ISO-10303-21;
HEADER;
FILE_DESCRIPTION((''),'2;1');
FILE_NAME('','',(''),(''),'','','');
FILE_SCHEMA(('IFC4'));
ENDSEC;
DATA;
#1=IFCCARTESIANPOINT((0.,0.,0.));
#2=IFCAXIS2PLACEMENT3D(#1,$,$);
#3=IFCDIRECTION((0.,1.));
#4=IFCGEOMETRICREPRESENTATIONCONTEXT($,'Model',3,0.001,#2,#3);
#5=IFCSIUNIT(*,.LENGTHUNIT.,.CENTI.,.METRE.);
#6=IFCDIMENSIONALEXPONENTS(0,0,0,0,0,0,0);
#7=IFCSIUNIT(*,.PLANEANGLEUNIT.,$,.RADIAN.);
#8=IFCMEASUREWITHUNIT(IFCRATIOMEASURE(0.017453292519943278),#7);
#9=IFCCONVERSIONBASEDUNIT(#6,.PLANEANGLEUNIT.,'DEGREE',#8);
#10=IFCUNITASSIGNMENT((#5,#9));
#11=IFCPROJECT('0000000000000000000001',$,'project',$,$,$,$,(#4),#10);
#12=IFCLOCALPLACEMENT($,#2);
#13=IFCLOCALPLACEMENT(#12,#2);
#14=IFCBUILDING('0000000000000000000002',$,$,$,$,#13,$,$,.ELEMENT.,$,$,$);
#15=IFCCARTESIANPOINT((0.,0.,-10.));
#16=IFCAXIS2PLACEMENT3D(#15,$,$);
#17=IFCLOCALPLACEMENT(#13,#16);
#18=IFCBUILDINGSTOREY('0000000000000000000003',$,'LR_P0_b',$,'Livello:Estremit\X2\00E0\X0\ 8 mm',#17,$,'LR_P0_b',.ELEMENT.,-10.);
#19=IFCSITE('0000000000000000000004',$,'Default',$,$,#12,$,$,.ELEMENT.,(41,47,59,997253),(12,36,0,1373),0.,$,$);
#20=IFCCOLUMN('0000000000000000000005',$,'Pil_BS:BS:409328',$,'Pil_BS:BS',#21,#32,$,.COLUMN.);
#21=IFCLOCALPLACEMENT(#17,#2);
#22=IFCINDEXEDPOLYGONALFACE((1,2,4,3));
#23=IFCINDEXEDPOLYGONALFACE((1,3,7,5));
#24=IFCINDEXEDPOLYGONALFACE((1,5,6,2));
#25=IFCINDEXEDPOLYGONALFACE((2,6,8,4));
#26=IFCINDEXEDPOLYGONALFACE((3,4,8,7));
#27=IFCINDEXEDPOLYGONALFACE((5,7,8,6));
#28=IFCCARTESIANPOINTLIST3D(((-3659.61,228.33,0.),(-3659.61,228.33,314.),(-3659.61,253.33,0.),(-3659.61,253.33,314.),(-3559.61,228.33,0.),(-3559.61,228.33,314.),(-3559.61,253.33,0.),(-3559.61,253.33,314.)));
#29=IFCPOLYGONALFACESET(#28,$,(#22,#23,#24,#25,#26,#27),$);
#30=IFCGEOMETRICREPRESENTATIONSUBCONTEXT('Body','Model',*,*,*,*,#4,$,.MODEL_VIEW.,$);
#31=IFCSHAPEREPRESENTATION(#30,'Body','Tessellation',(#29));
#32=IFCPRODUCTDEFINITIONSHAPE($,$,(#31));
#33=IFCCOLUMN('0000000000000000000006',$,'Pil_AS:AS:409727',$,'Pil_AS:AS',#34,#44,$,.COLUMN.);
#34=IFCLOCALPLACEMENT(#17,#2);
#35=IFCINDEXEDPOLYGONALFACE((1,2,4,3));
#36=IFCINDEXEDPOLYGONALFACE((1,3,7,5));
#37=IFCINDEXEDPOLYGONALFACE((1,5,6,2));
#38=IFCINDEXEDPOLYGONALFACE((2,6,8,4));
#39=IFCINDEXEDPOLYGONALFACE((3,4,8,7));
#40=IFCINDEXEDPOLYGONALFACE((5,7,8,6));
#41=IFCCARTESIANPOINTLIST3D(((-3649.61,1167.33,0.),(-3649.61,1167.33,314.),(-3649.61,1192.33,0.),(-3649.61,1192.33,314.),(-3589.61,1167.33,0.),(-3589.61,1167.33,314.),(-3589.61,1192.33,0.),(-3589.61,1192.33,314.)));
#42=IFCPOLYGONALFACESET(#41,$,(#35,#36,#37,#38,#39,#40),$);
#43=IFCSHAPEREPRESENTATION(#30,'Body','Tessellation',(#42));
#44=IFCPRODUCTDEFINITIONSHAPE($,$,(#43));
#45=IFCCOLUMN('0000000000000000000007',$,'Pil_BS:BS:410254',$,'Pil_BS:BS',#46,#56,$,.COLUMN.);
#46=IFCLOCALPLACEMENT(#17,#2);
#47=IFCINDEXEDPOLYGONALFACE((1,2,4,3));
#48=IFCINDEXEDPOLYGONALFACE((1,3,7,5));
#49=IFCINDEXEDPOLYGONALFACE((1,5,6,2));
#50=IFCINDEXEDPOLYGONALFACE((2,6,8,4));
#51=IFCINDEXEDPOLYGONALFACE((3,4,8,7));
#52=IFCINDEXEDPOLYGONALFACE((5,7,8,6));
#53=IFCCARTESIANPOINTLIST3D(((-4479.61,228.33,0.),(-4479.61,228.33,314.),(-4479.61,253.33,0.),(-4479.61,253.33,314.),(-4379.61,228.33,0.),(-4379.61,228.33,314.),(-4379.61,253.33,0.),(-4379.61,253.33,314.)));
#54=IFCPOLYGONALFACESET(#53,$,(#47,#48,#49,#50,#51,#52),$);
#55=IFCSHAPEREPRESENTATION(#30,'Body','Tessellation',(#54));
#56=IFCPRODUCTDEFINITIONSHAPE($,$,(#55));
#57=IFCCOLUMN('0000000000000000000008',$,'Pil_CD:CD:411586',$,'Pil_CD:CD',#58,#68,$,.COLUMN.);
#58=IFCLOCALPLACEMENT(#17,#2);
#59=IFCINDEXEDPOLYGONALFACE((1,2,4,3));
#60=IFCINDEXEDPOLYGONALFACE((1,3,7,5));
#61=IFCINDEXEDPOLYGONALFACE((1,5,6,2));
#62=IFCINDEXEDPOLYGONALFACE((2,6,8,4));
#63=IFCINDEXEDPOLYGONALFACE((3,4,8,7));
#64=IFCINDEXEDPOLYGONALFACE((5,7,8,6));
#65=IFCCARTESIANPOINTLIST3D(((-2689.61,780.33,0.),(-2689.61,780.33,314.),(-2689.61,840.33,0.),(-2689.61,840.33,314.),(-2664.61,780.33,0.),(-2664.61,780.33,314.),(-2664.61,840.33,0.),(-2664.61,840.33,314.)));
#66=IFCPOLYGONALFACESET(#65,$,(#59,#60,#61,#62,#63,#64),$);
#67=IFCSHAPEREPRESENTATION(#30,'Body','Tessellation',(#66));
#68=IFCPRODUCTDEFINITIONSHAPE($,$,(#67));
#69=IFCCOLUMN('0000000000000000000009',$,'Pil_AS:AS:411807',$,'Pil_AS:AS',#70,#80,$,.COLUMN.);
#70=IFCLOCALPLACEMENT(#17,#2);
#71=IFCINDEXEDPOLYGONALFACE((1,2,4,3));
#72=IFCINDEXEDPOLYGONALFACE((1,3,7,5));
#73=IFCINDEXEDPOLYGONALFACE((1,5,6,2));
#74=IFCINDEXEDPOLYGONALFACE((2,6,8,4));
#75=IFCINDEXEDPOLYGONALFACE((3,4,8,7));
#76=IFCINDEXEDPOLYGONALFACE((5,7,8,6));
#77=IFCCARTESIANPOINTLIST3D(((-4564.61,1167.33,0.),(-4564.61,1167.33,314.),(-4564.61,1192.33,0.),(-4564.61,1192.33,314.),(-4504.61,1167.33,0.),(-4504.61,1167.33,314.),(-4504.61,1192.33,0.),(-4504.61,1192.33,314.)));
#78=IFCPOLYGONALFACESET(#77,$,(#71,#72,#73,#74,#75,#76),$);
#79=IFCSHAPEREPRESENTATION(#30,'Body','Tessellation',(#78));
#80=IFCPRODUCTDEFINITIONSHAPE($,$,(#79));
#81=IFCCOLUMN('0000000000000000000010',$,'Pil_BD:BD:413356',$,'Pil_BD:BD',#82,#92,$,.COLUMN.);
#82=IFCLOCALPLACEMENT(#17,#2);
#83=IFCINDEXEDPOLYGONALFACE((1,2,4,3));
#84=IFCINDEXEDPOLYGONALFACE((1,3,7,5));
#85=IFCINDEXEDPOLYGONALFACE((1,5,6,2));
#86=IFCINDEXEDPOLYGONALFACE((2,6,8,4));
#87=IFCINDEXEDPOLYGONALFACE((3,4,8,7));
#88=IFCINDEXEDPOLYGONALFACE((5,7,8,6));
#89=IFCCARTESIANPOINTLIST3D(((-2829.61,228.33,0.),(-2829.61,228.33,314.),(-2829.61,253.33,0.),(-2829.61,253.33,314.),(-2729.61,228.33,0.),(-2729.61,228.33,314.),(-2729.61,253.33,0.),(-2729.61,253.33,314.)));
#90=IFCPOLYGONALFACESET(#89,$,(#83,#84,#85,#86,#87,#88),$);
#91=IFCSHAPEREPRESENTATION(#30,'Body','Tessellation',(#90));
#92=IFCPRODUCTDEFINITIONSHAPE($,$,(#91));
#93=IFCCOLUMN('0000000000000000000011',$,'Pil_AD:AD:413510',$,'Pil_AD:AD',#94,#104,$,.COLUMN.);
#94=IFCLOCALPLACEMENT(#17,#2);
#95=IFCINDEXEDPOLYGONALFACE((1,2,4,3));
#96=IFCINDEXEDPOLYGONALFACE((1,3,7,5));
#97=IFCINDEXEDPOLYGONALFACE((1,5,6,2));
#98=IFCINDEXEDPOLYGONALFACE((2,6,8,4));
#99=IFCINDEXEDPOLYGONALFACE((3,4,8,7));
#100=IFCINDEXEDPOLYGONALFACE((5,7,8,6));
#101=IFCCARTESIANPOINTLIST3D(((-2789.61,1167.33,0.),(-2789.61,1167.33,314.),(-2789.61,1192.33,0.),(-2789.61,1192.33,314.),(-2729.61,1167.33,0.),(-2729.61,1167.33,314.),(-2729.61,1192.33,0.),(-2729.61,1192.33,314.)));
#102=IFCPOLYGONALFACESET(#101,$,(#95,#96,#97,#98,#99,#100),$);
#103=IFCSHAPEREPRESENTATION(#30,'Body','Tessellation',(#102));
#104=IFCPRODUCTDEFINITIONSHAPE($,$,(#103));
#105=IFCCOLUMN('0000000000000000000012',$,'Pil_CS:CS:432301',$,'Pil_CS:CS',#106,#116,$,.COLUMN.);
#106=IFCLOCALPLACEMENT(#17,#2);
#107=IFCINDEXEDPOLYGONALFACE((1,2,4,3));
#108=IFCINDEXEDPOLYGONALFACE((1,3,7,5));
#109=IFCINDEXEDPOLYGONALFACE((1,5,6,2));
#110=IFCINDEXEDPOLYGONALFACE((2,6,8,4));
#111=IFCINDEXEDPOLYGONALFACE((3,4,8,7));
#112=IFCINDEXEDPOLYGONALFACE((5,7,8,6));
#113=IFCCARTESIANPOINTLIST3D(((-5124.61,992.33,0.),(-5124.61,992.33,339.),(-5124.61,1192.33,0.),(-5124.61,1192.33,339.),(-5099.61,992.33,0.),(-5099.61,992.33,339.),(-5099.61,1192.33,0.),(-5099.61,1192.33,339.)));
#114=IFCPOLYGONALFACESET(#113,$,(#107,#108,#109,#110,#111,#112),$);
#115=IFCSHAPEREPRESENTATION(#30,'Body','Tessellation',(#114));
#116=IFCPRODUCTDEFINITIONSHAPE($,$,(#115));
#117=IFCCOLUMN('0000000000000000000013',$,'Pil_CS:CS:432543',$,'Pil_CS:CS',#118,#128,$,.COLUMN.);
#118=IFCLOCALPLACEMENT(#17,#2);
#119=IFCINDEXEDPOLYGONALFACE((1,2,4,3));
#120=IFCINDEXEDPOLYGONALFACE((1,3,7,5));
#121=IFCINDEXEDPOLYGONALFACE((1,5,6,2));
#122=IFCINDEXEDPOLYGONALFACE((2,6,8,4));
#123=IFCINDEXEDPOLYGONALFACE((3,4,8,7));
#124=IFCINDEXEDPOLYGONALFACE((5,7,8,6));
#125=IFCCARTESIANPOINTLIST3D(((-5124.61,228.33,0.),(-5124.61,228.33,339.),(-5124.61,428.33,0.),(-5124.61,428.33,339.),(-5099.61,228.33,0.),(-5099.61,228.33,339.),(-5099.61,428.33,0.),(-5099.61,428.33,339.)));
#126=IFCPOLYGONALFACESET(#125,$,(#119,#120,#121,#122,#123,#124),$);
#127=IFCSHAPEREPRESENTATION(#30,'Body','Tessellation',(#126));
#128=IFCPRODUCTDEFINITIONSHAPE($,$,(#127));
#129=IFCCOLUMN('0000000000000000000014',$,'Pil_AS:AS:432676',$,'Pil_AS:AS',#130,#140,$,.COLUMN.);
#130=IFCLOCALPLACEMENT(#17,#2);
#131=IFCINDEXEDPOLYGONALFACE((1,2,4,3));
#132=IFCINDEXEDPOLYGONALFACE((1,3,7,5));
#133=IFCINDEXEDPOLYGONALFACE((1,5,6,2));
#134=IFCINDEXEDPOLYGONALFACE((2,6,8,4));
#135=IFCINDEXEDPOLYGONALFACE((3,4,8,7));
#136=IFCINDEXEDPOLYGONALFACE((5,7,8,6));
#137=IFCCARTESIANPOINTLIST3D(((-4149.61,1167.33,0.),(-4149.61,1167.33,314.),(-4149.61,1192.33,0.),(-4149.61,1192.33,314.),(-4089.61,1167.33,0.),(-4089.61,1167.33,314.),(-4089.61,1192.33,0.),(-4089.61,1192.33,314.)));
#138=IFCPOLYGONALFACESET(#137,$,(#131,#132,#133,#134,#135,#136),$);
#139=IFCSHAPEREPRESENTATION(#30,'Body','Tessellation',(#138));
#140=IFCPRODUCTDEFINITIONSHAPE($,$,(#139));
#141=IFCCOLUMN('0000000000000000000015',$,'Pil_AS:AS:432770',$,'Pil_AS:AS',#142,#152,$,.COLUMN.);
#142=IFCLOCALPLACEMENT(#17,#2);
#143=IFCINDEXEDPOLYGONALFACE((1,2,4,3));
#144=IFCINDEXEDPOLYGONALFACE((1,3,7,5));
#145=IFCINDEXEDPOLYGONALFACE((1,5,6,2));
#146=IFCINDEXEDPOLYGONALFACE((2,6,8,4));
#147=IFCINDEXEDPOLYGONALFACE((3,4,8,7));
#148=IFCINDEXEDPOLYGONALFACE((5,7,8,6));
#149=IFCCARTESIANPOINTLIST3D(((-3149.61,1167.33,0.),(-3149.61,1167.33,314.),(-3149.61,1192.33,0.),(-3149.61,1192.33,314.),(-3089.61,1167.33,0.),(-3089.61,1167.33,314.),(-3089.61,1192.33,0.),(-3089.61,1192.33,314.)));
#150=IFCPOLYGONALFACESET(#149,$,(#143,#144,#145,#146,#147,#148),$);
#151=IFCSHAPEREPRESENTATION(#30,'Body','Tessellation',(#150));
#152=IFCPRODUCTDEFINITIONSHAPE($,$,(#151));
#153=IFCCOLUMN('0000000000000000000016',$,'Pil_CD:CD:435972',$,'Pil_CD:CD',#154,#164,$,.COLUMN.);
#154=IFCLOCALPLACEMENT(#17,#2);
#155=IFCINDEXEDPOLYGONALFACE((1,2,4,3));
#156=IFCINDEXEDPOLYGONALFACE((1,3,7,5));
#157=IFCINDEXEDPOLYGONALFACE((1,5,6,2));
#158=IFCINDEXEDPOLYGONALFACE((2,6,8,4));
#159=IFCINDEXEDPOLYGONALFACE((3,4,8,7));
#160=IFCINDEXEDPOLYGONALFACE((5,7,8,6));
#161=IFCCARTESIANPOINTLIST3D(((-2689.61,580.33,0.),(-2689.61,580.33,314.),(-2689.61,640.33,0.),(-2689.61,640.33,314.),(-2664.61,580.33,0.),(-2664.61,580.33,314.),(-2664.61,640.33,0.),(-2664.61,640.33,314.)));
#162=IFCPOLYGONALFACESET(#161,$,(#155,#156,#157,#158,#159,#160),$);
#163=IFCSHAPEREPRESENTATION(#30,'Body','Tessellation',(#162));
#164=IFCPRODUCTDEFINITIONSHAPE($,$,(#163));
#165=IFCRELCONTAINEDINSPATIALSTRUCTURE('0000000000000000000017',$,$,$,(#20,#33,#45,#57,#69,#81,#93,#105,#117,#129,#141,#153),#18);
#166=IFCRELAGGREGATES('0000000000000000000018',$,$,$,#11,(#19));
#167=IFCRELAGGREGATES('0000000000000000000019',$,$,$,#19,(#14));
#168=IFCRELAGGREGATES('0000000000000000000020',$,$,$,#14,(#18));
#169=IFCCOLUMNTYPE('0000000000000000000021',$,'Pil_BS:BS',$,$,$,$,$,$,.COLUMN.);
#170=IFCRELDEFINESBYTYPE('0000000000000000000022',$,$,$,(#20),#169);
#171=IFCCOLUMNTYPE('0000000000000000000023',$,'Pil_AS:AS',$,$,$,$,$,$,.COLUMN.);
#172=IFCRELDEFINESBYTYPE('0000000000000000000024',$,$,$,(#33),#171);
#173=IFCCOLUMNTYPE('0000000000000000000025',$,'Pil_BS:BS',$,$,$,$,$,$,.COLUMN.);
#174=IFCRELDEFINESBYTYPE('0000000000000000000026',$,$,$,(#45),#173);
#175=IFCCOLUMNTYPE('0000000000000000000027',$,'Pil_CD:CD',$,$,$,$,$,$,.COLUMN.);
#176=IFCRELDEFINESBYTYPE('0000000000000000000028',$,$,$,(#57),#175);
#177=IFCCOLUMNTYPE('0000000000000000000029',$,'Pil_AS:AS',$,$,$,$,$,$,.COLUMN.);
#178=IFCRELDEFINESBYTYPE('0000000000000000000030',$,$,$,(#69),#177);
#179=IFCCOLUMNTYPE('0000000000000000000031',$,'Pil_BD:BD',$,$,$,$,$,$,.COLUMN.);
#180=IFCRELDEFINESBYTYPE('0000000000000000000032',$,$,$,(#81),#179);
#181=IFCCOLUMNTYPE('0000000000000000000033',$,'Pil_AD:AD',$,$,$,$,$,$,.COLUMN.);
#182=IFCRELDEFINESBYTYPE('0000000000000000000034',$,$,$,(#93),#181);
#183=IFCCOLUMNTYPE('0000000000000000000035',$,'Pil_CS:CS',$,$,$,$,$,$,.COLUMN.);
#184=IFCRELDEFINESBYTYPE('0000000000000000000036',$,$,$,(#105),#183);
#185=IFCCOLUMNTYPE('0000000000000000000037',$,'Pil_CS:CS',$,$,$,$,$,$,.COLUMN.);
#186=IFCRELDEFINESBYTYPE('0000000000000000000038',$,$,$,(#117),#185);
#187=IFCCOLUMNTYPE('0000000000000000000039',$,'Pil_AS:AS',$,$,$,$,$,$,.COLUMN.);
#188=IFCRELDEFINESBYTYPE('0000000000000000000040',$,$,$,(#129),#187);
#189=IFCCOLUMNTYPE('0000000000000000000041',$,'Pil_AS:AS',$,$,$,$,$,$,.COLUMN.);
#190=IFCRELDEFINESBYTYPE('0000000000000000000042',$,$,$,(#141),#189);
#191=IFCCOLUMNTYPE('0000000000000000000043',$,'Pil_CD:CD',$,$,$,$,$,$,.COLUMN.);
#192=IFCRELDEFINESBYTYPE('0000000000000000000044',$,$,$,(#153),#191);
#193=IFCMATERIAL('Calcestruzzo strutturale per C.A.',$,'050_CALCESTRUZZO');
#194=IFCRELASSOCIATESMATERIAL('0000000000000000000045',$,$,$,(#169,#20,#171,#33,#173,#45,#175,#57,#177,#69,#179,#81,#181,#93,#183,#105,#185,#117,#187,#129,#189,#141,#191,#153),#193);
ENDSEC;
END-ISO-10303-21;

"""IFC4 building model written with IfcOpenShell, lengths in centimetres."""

from ifc_helpers import new_model, entity, si_unit, converted_unit, direction, frame, origin, place, context, subcontext, project, spatial, indexed_curve, outline, extrude, source, transform, mapped, material, type_object, type_shapes, element, save


model = new_model("IFC4")

# Units and contexts
model_context = context("Model", 3, precision=0.001, world=origin(), true_north=direction((0.0, 1.0)))
body_context = subcontext(model_context, "Body", "Model", "MODEL_VIEW")
ifc_project = project(units=[si_unit("LENGTHUNIT", "METRE", prefix="CENTI"), converted_unit("PLANEANGLEUNIT", "DEGREE", entity("IfcRatioMeasure", 0.017453292519943278), si_unit("PLANEANGLEUNIT", "RADIAN"), dimensions=[0, 0, 0, 0, 0, 0, 0])], contexts=[model_context])

# Site, building, storey
site_placement = place(None, origin())
site = spatial("IfcSite", under=ifc_project, at=site_placement, Name="Default", CompositionType="ELEMENT", RefLatitude=(41, 47, 59, 997253), RefLongitude=(12, 36, 0, 1373), RefElevation=0.0)
building_placement = place(site_placement, origin())
building = spatial("IfcBuilding", under=site, at=building_placement, CompositionType="ELEMENT")
storey_placement = place(building_placement, frame((0.0, 0.0, -10.0)))
storey = spatial("IfcBuildingStorey", under=building, at=storey_placement, Name="LR_P0_b", ObjectType="Livello:Estremità 8 mm", LongName="LR_P0_b", CompositionType="ELEMENT", Elevation=-10.0)

# Columns
ifc_material = material(Name="Calcestruzzo strutturale per C.A.", Category="050_CALCESTRUZZO")
column_type_1 = type_object("IfcColumnType", Name="Pil_BS:BS", PredefinedType="COLUMN", material=ifc_material)
shared_shape_1 = source(origin(), body_context, "Body", "SweptSolid", [
    extrude(outline(indexed_curve([(-12.5, -50.0), (12.5, -50.0), (12.5, 50.0), (-12.5, 50.0), (-12.5, -50.0)], self_intersect=False)), frame((-3609.61, 240.83, -10.0), z_axis=(0.0, 0.0, 1.0), x_axis=(0.0, -1.0, 0.0)), (0.0, 0.0, 1.0), 314.0),
])
type_shapes(column_type_1, [shared_shape_1])
column_1_placement = place(storey_placement, frame((0.0, 0.0, 10.0)))
element("IfcColumn", 1, at=column_1_placement, inside=storey, type_object=column_type_1, material=ifc_material, Name="Pil_BS:BS:409328", ObjectType="Pil_BS:BS", PredefinedType="COLUMN", context=body_context, shape_type="MappedRepresentation", body=[
    mapped(shared_shape_1, transform((0.0, 0.0, 0.0), scale=1.0)),
])
column_type_2 = type_object("IfcColumnType", Name="Pil_AS:AS", PredefinedType="COLUMN", material=ifc_material)
shared_shape_2 = source(origin(), body_context, "Body", "SweptSolid", [
    extrude(outline(indexed_curve([(-12.5, -30.0), (12.5, -30.0), (12.5, 30.0), (-12.5, 30.0), (-12.5, -30.0)], self_intersect=False)), frame((-3619.61, 1179.83, -10.0), z_axis=(0.0, 0.0, 1.0), x_axis=(0.0, -1.0, 0.0)), (0.0, 0.0, 1.0), 314.0),
])
type_shapes(column_type_2, [shared_shape_2])
column_2_placement = place(storey_placement, frame((0.0, 0.0, 10.0)))
element("IfcColumn", 2, at=column_2_placement, inside=storey, type_object=column_type_2, material=ifc_material, Name="Pil_AS:AS:409727", ObjectType="Pil_AS:AS", PredefinedType="COLUMN", context=body_context, shape_type="MappedRepresentation", body=[
    mapped(shared_shape_2, transform((0.0, 0.0, 0.0), scale=1.0)),
])
column_type_3 = type_object("IfcColumnType", Name="Pil_BS:BS", PredefinedType="COLUMN", material=ifc_material)
shared_shape_3 = source(origin(), body_context, "Body", "SweptSolid", [
    extrude(outline(indexed_curve([(-12.5, -50.0), (12.5, -50.0), (12.5, 50.0), (-12.5, 50.0), (-12.5, -50.0)], self_intersect=False)), frame((-4429.61, 240.83, -10.0), z_axis=(0.0, 0.0, 1.0), x_axis=(0.0, -1.0, 0.0)), (0.0, 0.0, 1.0), 314.0),
])
type_shapes(column_type_3, [shared_shape_3])
column_3_placement = place(storey_placement, frame((0.0, 0.0, 10.0)))
element("IfcColumn", 3, at=column_3_placement, inside=storey, type_object=column_type_3, material=ifc_material, Name="Pil_BS:BS:410254", ObjectType="Pil_BS:BS", PredefinedType="COLUMN", context=body_context, shape_type="MappedRepresentation", body=[
    mapped(shared_shape_3, transform((0.0, 0.0, 0.0), scale=1.0)),
])
column_type_4 = type_object("IfcColumnType", Name="Pil_CD:CD", PredefinedType="COLUMN", material=ifc_material)
shared_shape_4 = source(origin(), body_context, "Body", "SweptSolid", [
    extrude(outline(indexed_curve([(-30.0, -12.5), (30.0, -12.5), (30.0, 12.5), (-30.0, 12.5), (-30.0, -12.5)], self_intersect=False)), frame((-2677.11, 810.33, -10.0), z_axis=(0.0, 0.0, 1.0), x_axis=(0.0, -1.0, 0.0)), (0.0, 0.0, 1.0), 314.0),
])
type_shapes(column_type_4, [shared_shape_4])
column_4_placement = place(storey_placement, frame((0.0, 0.0, 10.0)))
element("IfcColumn", 4, at=column_4_placement, inside=storey, type_object=column_type_4, material=ifc_material, Name="Pil_CD:CD:411586", ObjectType="Pil_CD:CD", PredefinedType="COLUMN", context=body_context, shape_type="MappedRepresentation", body=[
    mapped(shared_shape_4, transform((0.0, 0.0, 0.0), scale=1.0)),
])
column_type_5 = type_object("IfcColumnType", Name="Pil_AS:AS", PredefinedType="COLUMN", material=ifc_material)
shared_shape_5 = source(origin(), body_context, "Body", "SweptSolid", [
    extrude(outline(indexed_curve([(-12.5, -30.0), (12.5, -30.0), (12.5, 30.0), (-12.5, 30.0), (-12.5, -30.0)], self_intersect=False)), frame((-4534.61, 1179.83, -10.0), z_axis=(0.0, 0.0, 1.0), x_axis=(0.0, -1.0, 0.0)), (0.0, 0.0, 1.0), 314.0),
])
type_shapes(column_type_5, [shared_shape_5])
column_5_placement = place(storey_placement, frame((0.0, 0.0, 10.0)))
element("IfcColumn", 5, at=column_5_placement, inside=storey, type_object=column_type_5, material=ifc_material, Name="Pil_AS:AS:411807", ObjectType="Pil_AS:AS", PredefinedType="COLUMN", context=body_context, shape_type="MappedRepresentation", body=[
    mapped(shared_shape_5, transform((0.0, 0.0, 0.0), scale=1.0)),
])
column_type_6 = type_object("IfcColumnType", Name="Pil_BD:BD", PredefinedType="COLUMN", material=ifc_material)
shared_shape_6 = source(origin(), body_context, "Body", "SweptSolid", [
    extrude(outline(indexed_curve([(-12.5, -50.0), (12.5, -50.0), (12.5, 50.0), (-12.5, 50.0), (-12.5, -50.0)], self_intersect=False)), frame((-2779.61, 240.83, -10.0), z_axis=(0.0, 0.0, 1.0), x_axis=(0.0, -1.0, 0.0)), (0.0, 0.0, 1.0), 314.0),
])
type_shapes(column_type_6, [shared_shape_6])
column_6_placement = place(storey_placement, frame((0.0, 0.0, 10.0)))
element("IfcColumn", 6, at=column_6_placement, inside=storey, type_object=column_type_6, material=ifc_material, Name="Pil_BD:BD:413356", ObjectType="Pil_BD:BD", PredefinedType="COLUMN", context=body_context, shape_type="MappedRepresentation", body=[
    mapped(shared_shape_6, transform((0.0, 0.0, 0.0), scale=1.0)),
])
column_type_7 = type_object("IfcColumnType", Name="Pil_AD:AD", PredefinedType="COLUMN", material=ifc_material)
shared_shape_7 = source(origin(), body_context, "Body", "SweptSolid", [
    extrude(outline(indexed_curve([(-12.5, -30.0), (12.5, -30.0), (12.5, 30.0), (-12.5, 30.0), (-12.5, -30.0)], self_intersect=False)), frame((-2759.61, 1179.83, -10.0), z_axis=(0.0, 0.0, 1.0), x_axis=(0.0, -1.0, 0.0)), (0.0, 0.0, 1.0), 314.0),
])
type_shapes(column_type_7, [shared_shape_7])
column_7_placement = place(storey_placement, frame((0.0, 0.0, 10.0)))
element("IfcColumn", 7, at=column_7_placement, inside=storey, type_object=column_type_7, material=ifc_material, Name="Pil_AD:AD:413510", ObjectType="Pil_AD:AD", PredefinedType="COLUMN", context=body_context, shape_type="MappedRepresentation", body=[
    mapped(shared_shape_7, transform((0.0, 0.0, 0.0), scale=1.0)),
])
column_type_8 = type_object("IfcColumnType", Name="Pil_CS:CS", PredefinedType="COLUMN", material=ifc_material)
shared_shape_8 = source(origin(), body_context, "Body", "SweptSolid", [
    extrude(outline(indexed_curve([(-100.0, -12.5), (100.0, -12.5), (100.0, 12.5), (-100.0, 12.5), (-100.0, -12.5)], self_intersect=False)), frame((-5112.11, 1092.33, -10.0), z_axis=(0.0, 0.0, 1.0), x_axis=(0.0, -1.0, 0.0)), (0.0, 0.0, 1.0), 339.0),
])
type_shapes(column_type_8, [shared_shape_8])
column_8_placement = place(storey_placement, frame((0.0, 0.0, 10.0)))
element("IfcColumn", 8, at=column_8_placement, inside=storey, type_object=column_type_8, material=ifc_material, Name="Pil_CS:CS:432301", ObjectType="Pil_CS:CS", PredefinedType="COLUMN", context=body_context, shape_type="MappedRepresentation", body=[
    mapped(shared_shape_8, transform((0.0, 0.0, 0.0), scale=1.0)),
])
column_type_9 = type_object("IfcColumnType", Name="Pil_CS:CS", PredefinedType="COLUMN", material=ifc_material)
shared_shape_9 = source(origin(), body_context, "Body", "SweptSolid", [
    extrude(outline(indexed_curve([(-100.0, -12.5), (100.0, -12.5), (100.0, 12.5), (-100.0, 12.5), (-100.0, -12.5)], self_intersect=False)), frame((-5112.11, 328.33, -10.0), z_axis=(0.0, 0.0, 1.0), x_axis=(0.0, -1.0, 0.0)), (0.0, 0.0, 1.0), 339.0),
])
type_shapes(column_type_9, [shared_shape_9])
column_9_placement = place(storey_placement, frame((0.0, 0.0, 10.0)))
element("IfcColumn", 9, at=column_9_placement, inside=storey, type_object=column_type_9, material=ifc_material, Name="Pil_CS:CS:432543", ObjectType="Pil_CS:CS", PredefinedType="COLUMN", context=body_context, shape_type="MappedRepresentation", body=[
    mapped(shared_shape_9, transform((0.0, 0.0, 0.0), scale=1.0)),
])
column_type_10 = type_object("IfcColumnType", Name="Pil_AS:AS", PredefinedType="COLUMN", material=ifc_material)
shared_shape_10 = source(origin(), body_context, "Body", "SweptSolid", [
    extrude(outline(indexed_curve([(-12.5, -30.0), (12.5, -30.0), (12.5, 30.0), (-12.5, 30.0), (-12.5, -30.0)], self_intersect=False)), frame((-4119.61, 1179.83, -10.0), z_axis=(0.0, 0.0, 1.0), x_axis=(0.0, -1.0, 0.0)), (0.0, 0.0, 1.0), 314.0),
])
type_shapes(column_type_10, [shared_shape_10])
column_10_placement = place(storey_placement, frame((0.0, 0.0, 10.0)))
element("IfcColumn", 10, at=column_10_placement, inside=storey, type_object=column_type_10, material=ifc_material, Name="Pil_AS:AS:432676", ObjectType="Pil_AS:AS", PredefinedType="COLUMN", context=body_context, shape_type="MappedRepresentation", body=[
    mapped(shared_shape_10, transform((0.0, 0.0, 0.0), scale=1.0)),
])
column_type_11 = type_object("IfcColumnType", Name="Pil_AS:AS", PredefinedType="COLUMN", material=ifc_material)
shared_shape_11 = source(origin(), body_context, "Body", "SweptSolid", [
    extrude(outline(indexed_curve([(-12.5, -30.0), (12.5, -30.0), (12.5, 30.0), (-12.5, 30.0), (-12.5, -30.0)], self_intersect=False)), frame((-3119.61, 1179.83, -10.0), z_axis=(0.0, 0.0, 1.0), x_axis=(0.0, -1.0, 0.0)), (0.0, 0.0, 1.0), 314.0),
])
type_shapes(column_type_11, [shared_shape_11])
column_11_placement = place(storey_placement, frame((0.0, 0.0, 10.0)))
element("IfcColumn", 11, at=column_11_placement, inside=storey, type_object=column_type_11, material=ifc_material, Name="Pil_AS:AS:432770", ObjectType="Pil_AS:AS", PredefinedType="COLUMN", context=body_context, shape_type="MappedRepresentation", body=[
    mapped(shared_shape_11, transform((0.0, 0.0, 0.0), scale=1.0)),
])
column_type_12 = type_object("IfcColumnType", Name="Pil_CD:CD", PredefinedType="COLUMN", material=ifc_material)
shared_shape_12 = source(origin(), body_context, "Body", "SweptSolid", [
    extrude(outline(indexed_curve([(-30.0, -12.5), (30.0, -12.5), (30.0, 12.5), (-30.0, 12.5), (-30.0, -12.5)], self_intersect=False)), frame((-2677.11, 610.33, -10.0), z_axis=(0.0, 0.0, 1.0), x_axis=(0.0, -1.0, 0.0)), (0.0, 0.0, 1.0), 314.0),
])
type_shapes(column_type_12, [shared_shape_12])
column_12_placement = place(storey_placement, frame((0.0, 0.0, 10.0)))
element("IfcColumn", 12, at=column_12_placement, inside=storey, type_object=column_type_12, material=ifc_material, Name="Pil_CD:CD:435972", ObjectType="Pil_CD:CD", PredefinedType="COLUMN", context=body_context, shape_type="MappedRepresentation", body=[
    mapped(shared_shape_12, transform((0.0, 0.0, 0.0), scale=1.0)),
])

save(model, "model.ifc")
